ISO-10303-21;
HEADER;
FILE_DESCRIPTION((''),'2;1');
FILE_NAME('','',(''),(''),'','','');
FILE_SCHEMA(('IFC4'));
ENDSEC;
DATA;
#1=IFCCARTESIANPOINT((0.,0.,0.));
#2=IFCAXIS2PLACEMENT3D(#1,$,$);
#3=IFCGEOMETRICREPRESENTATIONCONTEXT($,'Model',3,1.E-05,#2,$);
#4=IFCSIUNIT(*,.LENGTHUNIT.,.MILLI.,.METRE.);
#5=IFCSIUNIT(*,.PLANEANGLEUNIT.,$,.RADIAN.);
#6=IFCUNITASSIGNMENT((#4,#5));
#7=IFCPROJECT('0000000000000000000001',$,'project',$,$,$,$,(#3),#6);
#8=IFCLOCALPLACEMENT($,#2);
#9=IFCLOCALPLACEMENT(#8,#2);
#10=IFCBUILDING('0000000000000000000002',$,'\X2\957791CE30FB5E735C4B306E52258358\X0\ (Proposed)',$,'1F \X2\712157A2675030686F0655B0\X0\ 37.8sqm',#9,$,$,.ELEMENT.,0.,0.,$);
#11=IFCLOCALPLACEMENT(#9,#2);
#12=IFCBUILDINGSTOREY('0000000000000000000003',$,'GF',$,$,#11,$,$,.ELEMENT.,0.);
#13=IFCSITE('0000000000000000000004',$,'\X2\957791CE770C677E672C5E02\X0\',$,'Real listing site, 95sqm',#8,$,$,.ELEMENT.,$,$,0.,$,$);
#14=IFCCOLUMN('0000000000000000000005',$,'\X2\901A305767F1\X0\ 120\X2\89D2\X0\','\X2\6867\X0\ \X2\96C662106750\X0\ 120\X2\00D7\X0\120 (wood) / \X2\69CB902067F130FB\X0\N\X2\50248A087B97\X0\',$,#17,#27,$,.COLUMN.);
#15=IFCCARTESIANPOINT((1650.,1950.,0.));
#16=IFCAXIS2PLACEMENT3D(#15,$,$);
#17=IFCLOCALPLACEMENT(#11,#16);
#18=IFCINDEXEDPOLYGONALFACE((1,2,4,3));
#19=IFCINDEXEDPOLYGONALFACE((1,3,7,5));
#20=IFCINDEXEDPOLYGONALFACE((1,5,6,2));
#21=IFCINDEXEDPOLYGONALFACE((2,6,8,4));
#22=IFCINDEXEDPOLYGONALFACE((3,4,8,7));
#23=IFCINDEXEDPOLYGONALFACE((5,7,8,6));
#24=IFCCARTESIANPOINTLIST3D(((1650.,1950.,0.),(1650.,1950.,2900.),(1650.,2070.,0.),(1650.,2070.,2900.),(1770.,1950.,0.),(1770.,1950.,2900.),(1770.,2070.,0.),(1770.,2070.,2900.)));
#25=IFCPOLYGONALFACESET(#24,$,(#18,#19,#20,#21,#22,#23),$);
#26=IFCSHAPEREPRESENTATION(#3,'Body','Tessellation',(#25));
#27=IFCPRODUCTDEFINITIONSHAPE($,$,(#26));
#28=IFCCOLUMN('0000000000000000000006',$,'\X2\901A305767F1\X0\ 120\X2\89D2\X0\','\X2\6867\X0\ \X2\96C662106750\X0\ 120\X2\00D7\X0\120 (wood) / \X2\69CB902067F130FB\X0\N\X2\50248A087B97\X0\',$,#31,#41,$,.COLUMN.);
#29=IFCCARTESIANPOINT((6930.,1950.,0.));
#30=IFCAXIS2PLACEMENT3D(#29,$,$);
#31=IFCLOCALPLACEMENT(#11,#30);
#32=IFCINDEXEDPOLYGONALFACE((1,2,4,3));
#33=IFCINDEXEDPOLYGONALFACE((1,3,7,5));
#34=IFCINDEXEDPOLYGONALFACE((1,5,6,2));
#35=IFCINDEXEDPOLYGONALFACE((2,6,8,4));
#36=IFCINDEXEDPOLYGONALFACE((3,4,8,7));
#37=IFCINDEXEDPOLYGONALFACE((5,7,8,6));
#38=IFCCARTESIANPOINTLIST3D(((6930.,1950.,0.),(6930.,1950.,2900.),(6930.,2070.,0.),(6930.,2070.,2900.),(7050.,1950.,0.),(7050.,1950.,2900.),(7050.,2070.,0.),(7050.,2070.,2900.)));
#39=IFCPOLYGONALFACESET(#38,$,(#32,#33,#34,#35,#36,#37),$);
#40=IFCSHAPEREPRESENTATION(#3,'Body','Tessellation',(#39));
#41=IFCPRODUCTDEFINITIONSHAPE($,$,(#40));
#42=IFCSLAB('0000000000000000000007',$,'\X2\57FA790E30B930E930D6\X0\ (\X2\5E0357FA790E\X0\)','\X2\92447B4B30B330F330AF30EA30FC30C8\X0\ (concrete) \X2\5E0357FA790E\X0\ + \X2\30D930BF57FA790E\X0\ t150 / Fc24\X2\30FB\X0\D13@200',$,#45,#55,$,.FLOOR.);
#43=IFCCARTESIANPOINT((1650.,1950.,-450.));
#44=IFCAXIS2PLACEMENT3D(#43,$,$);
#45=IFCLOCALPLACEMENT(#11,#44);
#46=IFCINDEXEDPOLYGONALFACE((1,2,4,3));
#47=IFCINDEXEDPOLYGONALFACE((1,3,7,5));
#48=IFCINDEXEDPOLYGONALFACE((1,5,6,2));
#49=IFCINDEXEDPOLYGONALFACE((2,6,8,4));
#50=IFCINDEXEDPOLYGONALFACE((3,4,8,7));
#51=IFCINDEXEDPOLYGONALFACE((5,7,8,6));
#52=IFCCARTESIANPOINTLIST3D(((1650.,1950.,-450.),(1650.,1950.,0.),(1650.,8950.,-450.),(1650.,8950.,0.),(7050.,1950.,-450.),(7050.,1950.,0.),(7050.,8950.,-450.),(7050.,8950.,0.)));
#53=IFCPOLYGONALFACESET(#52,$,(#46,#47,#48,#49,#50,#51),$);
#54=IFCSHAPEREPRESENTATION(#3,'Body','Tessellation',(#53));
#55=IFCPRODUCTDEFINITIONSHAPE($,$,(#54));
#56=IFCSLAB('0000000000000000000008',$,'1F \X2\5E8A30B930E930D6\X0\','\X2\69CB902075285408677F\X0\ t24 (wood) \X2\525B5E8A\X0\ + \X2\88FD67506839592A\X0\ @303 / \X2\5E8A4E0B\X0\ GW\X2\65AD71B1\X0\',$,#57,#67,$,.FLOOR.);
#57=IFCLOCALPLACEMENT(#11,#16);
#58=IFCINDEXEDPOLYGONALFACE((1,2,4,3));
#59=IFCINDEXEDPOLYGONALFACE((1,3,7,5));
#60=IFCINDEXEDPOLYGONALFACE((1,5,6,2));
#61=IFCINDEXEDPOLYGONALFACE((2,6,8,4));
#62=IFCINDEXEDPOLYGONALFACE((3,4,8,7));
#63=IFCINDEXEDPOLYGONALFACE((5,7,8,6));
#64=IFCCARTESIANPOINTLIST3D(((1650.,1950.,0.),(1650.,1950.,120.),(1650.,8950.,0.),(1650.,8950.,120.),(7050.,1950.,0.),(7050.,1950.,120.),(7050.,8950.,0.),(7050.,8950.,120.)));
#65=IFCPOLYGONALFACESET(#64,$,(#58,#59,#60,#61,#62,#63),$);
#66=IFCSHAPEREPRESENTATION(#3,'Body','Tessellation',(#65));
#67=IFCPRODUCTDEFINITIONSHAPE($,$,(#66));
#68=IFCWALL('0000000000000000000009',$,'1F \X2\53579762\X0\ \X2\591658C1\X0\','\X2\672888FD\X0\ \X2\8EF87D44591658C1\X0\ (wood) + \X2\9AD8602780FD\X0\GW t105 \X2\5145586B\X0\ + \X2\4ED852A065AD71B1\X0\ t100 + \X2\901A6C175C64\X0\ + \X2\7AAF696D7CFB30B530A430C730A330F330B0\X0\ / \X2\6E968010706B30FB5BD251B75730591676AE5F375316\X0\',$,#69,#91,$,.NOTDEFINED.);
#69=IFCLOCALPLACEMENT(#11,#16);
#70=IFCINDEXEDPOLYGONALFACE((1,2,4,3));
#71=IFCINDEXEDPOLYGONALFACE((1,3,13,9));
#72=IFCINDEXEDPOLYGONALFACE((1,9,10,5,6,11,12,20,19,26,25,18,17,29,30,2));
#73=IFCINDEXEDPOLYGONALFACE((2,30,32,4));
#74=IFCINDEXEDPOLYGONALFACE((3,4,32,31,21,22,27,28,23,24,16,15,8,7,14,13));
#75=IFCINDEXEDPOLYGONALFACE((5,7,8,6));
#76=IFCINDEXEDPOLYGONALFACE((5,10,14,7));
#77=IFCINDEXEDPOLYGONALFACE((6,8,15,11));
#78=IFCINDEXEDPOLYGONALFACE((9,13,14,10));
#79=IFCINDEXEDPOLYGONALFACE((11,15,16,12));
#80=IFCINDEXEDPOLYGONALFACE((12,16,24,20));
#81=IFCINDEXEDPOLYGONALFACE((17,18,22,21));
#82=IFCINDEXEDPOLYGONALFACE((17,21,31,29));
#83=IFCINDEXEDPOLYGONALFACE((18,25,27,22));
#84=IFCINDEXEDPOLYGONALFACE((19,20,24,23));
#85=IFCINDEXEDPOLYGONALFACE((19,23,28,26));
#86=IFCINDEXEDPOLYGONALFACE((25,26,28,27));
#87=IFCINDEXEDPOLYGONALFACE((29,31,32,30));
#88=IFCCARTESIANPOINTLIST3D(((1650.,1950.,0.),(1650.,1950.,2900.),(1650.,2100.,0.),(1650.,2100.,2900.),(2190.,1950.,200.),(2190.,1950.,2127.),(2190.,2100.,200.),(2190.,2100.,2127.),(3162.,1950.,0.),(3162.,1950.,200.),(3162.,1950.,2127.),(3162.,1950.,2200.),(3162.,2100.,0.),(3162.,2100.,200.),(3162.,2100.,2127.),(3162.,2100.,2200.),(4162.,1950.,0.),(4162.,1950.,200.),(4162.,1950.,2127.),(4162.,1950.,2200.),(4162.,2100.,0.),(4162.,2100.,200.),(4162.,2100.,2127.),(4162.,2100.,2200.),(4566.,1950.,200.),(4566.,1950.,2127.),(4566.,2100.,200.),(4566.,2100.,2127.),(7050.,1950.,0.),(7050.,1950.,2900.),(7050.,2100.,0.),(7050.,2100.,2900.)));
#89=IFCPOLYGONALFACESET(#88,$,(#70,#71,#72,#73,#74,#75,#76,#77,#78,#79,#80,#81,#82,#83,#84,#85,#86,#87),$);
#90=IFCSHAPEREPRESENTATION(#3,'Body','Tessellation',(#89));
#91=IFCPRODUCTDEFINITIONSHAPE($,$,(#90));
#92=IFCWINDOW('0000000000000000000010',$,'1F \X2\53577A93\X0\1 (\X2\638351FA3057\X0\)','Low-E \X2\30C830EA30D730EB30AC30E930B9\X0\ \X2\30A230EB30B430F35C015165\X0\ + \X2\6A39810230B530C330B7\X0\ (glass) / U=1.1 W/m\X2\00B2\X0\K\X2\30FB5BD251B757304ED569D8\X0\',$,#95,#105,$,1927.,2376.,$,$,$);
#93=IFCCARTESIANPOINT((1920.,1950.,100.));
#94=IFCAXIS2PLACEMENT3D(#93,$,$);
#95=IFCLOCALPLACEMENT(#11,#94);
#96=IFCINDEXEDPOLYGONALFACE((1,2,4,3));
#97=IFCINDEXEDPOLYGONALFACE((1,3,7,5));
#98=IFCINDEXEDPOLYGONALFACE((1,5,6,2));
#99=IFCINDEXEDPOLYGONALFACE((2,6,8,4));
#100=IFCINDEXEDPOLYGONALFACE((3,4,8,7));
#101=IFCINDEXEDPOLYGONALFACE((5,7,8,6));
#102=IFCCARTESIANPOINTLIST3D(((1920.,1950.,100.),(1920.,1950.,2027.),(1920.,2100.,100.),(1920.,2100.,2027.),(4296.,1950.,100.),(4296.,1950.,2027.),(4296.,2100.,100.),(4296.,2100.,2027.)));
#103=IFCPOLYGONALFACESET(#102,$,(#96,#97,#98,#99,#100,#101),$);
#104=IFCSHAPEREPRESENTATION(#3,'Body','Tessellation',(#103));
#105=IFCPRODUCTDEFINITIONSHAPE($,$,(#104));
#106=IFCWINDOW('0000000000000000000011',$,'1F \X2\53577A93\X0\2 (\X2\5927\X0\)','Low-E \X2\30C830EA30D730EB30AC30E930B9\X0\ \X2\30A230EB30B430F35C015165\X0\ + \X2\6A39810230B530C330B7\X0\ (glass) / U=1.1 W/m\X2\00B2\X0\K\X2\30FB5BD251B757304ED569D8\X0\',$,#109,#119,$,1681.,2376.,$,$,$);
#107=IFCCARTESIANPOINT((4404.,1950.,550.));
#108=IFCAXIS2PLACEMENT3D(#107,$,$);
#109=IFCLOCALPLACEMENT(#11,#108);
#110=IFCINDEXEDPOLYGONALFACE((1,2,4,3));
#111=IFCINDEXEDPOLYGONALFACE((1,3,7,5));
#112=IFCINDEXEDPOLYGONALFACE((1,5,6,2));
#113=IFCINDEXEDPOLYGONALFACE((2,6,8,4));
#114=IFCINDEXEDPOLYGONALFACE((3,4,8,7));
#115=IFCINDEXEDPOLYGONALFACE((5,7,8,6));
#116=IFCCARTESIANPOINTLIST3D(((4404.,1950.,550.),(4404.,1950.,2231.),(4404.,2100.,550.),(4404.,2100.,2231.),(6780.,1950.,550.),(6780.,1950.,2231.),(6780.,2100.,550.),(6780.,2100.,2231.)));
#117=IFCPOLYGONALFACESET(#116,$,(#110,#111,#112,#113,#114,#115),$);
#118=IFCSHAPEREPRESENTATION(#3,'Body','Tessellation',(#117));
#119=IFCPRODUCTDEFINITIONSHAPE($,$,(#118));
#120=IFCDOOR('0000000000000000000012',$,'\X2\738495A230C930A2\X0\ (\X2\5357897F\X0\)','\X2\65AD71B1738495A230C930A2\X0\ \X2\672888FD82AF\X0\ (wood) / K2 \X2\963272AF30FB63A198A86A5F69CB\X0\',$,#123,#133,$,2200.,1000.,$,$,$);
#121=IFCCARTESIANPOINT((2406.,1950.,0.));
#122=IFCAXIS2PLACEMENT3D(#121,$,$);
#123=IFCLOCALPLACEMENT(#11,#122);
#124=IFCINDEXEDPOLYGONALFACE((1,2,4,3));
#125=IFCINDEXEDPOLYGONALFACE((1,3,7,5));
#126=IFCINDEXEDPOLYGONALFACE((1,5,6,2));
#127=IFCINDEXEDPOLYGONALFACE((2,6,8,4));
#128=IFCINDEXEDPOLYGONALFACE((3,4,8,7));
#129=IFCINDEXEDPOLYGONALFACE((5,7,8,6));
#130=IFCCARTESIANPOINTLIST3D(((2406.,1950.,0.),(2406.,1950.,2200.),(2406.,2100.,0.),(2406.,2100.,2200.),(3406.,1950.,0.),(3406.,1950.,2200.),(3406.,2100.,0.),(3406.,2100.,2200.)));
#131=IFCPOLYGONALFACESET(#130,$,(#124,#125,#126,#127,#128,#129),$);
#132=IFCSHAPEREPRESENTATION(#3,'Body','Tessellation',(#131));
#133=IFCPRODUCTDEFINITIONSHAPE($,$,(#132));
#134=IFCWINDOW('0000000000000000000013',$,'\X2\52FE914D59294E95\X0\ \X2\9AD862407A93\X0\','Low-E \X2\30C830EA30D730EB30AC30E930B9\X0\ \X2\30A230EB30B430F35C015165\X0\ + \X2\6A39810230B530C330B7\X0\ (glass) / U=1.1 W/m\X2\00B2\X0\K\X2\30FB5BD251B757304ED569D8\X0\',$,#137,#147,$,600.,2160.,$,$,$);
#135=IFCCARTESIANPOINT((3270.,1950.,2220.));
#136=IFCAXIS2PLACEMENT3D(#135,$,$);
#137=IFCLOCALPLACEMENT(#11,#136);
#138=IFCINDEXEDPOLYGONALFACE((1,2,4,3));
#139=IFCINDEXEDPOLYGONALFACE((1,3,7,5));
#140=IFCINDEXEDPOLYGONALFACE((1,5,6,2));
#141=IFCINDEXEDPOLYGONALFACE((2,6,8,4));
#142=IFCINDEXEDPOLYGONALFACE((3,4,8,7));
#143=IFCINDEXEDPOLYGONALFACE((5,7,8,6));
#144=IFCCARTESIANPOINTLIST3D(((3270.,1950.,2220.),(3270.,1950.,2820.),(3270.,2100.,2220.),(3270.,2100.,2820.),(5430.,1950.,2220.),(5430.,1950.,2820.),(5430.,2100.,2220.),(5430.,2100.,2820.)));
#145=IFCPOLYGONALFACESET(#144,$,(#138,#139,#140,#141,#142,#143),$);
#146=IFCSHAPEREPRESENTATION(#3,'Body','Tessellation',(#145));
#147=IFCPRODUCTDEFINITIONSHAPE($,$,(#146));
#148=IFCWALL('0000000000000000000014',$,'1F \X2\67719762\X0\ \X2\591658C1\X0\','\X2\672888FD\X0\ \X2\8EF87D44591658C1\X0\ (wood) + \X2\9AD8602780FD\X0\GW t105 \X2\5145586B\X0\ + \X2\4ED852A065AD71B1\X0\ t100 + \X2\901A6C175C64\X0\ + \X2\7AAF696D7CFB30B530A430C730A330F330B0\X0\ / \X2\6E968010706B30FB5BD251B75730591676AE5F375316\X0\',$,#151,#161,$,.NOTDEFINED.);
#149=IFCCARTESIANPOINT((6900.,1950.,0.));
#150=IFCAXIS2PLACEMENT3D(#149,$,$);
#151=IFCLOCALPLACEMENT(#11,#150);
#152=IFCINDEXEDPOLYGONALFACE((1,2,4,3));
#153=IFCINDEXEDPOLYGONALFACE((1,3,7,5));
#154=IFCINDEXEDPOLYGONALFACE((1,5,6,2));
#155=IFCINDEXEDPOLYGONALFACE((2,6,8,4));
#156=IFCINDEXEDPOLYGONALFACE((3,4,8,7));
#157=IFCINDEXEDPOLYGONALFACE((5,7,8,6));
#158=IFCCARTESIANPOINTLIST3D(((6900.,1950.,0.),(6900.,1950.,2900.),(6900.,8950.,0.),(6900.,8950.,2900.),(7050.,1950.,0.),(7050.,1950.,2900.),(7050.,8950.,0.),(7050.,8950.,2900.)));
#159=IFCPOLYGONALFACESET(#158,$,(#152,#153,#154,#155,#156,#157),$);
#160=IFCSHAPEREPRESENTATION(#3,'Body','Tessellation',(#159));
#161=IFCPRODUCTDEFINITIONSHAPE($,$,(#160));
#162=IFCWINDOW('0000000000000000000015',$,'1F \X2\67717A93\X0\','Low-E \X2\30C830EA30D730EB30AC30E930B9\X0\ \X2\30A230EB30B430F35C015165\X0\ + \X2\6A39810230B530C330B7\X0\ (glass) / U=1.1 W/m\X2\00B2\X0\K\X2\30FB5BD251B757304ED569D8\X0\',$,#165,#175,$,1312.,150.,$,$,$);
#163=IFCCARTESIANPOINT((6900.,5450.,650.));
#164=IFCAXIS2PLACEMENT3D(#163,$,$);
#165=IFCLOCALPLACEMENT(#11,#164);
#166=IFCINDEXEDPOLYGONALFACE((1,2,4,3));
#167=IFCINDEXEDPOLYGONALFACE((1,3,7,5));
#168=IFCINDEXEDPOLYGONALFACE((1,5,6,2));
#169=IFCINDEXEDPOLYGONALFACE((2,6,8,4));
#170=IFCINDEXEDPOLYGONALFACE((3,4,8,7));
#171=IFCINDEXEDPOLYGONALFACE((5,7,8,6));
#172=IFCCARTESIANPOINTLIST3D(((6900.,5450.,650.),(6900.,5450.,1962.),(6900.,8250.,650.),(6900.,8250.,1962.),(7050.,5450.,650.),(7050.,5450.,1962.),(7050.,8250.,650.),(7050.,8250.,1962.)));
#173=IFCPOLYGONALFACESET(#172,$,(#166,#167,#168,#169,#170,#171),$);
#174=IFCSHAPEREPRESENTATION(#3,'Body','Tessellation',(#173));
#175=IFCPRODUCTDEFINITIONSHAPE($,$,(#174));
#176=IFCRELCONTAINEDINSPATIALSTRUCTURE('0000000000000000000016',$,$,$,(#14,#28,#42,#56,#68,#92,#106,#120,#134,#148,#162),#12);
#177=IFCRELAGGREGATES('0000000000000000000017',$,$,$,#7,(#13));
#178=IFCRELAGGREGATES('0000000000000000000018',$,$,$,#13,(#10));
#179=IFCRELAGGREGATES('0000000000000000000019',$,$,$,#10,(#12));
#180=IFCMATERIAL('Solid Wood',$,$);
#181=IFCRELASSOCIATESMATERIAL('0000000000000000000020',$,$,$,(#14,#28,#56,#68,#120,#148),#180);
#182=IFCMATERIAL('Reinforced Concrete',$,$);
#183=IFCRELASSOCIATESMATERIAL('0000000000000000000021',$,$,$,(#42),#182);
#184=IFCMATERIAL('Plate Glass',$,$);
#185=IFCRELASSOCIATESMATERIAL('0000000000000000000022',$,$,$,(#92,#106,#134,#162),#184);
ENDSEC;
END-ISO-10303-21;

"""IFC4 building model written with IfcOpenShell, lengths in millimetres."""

from ifc_helpers import new_model, si_unit, frame, frame_2d, origin, place, context, project, spatial, rectangle, extrude, material, element, fill, save


model = new_model("IFC4")

# Units and contexts
model_context = context("Model", 3, precision=1e-05, world=origin())
ifc_project = project(units=[si_unit("LENGTHUNIT", "METRE", prefix="MILLI"), si_unit("PLANEANGLEUNIT", "RADIAN")], contexts=[model_context])

# Site, building, storey
site_placement = place(None, origin())
site = spatial("IfcSite", under=ifc_project, at=site_placement, Name="長野県松本市", ObjectType="Real listing site, 95sqm", CompositionType="ELEMENT", RefElevation=0.0)
building_placement = place(site_placement, origin())
building = spatial("IfcBuilding", under=site, at=building_placement, Name="長野・平屋の別荘 (Proposed)", ObjectType="1F 無垢材と漆喰 37.8sqm", CompositionType="ELEMENT", ElevationOfRefHeight=0.0, ElevationOfTerrain=0.0)
storey_placement = place(building_placement, origin())
storey = spatial("IfcBuildingStorey", under=building, at=storey_placement, Name="GF", CompositionType="ELEMENT", Elevation=0.0)

# Columns
ifc_material_1 = material(Name="Solid Wood")
column_1_placement = place(storey_placement, frame((1650.0, 1950.0, 0.0)))
element("IfcColumn", 1, at=column_1_placement, inside=storey, material=ifc_material_1, Name="通し柱 120角", Description="桧 集成材 120×120 (wood) / 構造柱・N値計算", PredefinedType="COLUMN", context=model_context, shape_type="SweptSolid", body=[
    extrude(rectangle(XDim=120.0, YDim=120.0, at=frame_2d((60.0, 60.0))), frame((1650.0, 1950.0, 0.0)), (0.0, 0.0, 1.0), 2900.0),
])
column_2_placement = place(storey_placement, frame((6930.0, 1950.0, 0.0)))
element("IfcColumn", 2, at=column_2_placement, inside=storey, material=ifc_material_1, Name="通し柱 120角", Description="桧 集成材 120×120 (wood) / 構造柱・N値計算", PredefinedType="COLUMN", context=model_context, shape_type="SweptSolid", body=[
    extrude(rectangle(XDim=120.0, YDim=120.0, at=frame_2d((60.0, 60.0))), frame((6930.0, 1950.0, 0.0)), (0.0, 0.0, 1.0), 2900.0),
])

# Slabs
ifc_material_2 = material(Name="Reinforced Concrete")
slab_1_placement = place(storey_placement, frame((1650.0, 1950.0, -450.0)))
element("IfcSlab", 3, at=slab_1_placement, inside=storey, material=ifc_material_2, Name="基礎スラブ (布基礎)", Description="鉄筋コンクリート (concrete) 布基礎 + ベタ基礎 t150 / Fc24・D13@200", PredefinedType="FLOOR", context=model_context, shape_type="SweptSolid", body=[
    extrude(rectangle(XDim=5400.0, YDim=7000.0, at=frame_2d((2700.0, 3500.0))), frame((1650.0, 1950.0, -450.0)), (0.0, 0.0, 1.0), 450.0),
])
slab_2_placement = place(storey_placement, frame((1650.0, 1950.0, 0.0)))
element("IfcSlab", 4, at=slab_2_placement, inside=storey, material=ifc_material_1, Name="1F 床スラブ", Description="構造用合板 t24 (wood) 剛床 + 製材根太 @303 / 床下 GW断熱", PredefinedType="FLOOR", context=model_context, shape_type="SweptSolid", body=[
    extrude(rectangle(XDim=5400.0, YDim=7000.0, at=frame_2d((2700.0, 3500.0))), frame((1650.0, 1950.0, 0.0)), (0.0, 0.0, 1.0), 120.0),
])

# Wall, openings, windows, door
wall_1_placement = place(storey_placement, frame((1650.0, 1950.0, 0.0)))
wall_1 = element("IfcWall", 5, at=wall_1_placement, inside=storey, material=ifc_material_1, Name="1F 南面 外壁", Description="木製 軸組外壁 (wood) + 高性能GW t105 充填 + 付加断熱 t100 + 通気層 + 窯業系サイディング / 準耐火・寒冷地外皮強化", PredefinedType="NOTDEFINED", context=model_context, shape_type="SweptSolid", body=[
    extrude(rectangle(XDim=5400.0, YDim=150.0, at=frame_2d((2700.0, 75.0))), frame((1650.0, 1950.0, 0.0)), (0.0, 0.0, 1.0), 2900.0),
])
opening_1_placement = place(storey_placement, frame((1920.0, 1950.0, 100.0)))
opening_1 = element("IfcOpeningElement", 6, at=opening_1_placement, cuts=wall_1, PredefinedType="NOTDEFINED", context=model_context, shape_type="SweptSolid", body=[
    extrude(rectangle(XDim=2376.0, YDim=150.0, at=frame_2d((1188.0, 75.0))), frame((1920.0, 1950.0, 100.0)), (0.0, 0.0, 1.0), 1927.0),
])
opening_2_placement = place(storey_placement, frame((4404.0, 1950.0, 550.0)))
opening_2 = element("IfcOpeningElement", 7, at=opening_2_placement, cuts=wall_1, PredefinedType="NOTDEFINED", context=model_context, shape_type="SweptSolid", body=[
    extrude(rectangle(XDim=2376.0, YDim=150.0, at=frame_2d((1188.0, 75.0))), frame((4404.0, 1950.0, 550.0)), (0.0, 0.0, 1.0), 1681.0),
])
opening_3_placement = place(storey_placement, frame((2406.0, 1950.0, 0.0)))
opening_3 = element("IfcOpeningElement", 8, at=opening_3_placement, cuts=wall_1, PredefinedType="NOTDEFINED", context=model_context, shape_type="SweptSolid", body=[
    extrude(rectangle(XDim=1000.0, YDim=150.0, at=frame_2d((500.0, 75.0))), frame((2406.0, 1950.0, 0.0)), (0.0, 0.0, 1.0), 2200.0),
])
opening_4_placement = place(storey_placement, frame((3270.0, 1950.0, 2220.0)))
opening_4 = element("IfcOpeningElement", 9, at=opening_4_placement, cuts=wall_1, PredefinedType="NOTDEFINED", context=model_context, shape_type="SweptSolid", body=[
    extrude(rectangle(XDim=2160.0, YDim=150.0, at=frame_2d((1080.0, 75.0))), frame((3270.0, 1950.0, 2220.0)), (0.0, 0.0, 1.0), 600.0),
])
ifc_material_3 = material(Name="Plate Glass")
window_1_placement = place(storey_placement, frame((1920.0, 1950.0, 100.0)))
window_1 = element("IfcWindow", 10, at=window_1_placement, inside=storey, material=ifc_material_3, Name="1F 南窓1 (掃出し)", Description="Low-E トリプルガラス アルゴン封入 + 樹脂サッシ (glass) / U=1.1 W/m²K・寒冷地仕様", OverallHeight=1927.0, OverallWidth=2376.0, context=model_context, shape_type="SweptSolid", body=[
    extrude(rectangle(XDim=2376.0, YDim=150.0, at=frame_2d((1188.0, 75.0))), frame((1920.0, 1950.0, 100.0)), (0.0, 0.0, 1.0), 1927.0),
])
fill(opening_1, window_1)
window_2_placement = place(storey_placement, frame((4404.0, 1950.0, 550.0)))
window_2 = element("IfcWindow", 11, at=window_2_placement, inside=storey, material=ifc_material_3, Name="1F 南窓2 (大)", Description="Low-E トリプルガラス アルゴン封入 + 樹脂サッシ (glass) / U=1.1 W/m²K・寒冷地仕様", OverallHeight=1681.0, OverallWidth=2376.0, context=model_context, shape_type="SweptSolid", body=[
    extrude(rectangle(XDim=2376.0, YDim=150.0, at=frame_2d((1188.0, 75.0))), frame((4404.0, 1950.0, 550.0)), (0.0, 0.0, 1.0), 1681.0),
])
fill(opening_2, window_2)
door_placement = place(storey_placement, frame((2406.0, 1950.0, 0.0)))
door = element("IfcDoor", 12, at=door_placement, inside=storey, material=ifc_material_1, Name="玄関ドア (南西)", Description="断熱玄関ドア 木製芯 (wood) / K2 防犯・採風機構", OverallHeight=2200.0, OverallWidth=1000.0, context=model_context, shape_type="SweptSolid", body=[
    extrude(rectangle(XDim=1000.0, YDim=150.0, at=frame_2d((500.0, 75.0))), frame((2406.0, 1950.0, 0.0)), (0.0, 0.0, 1.0), 2200.0),
])
fill(opening_3, door)
window_3_placement = place(storey_placement, frame((3270.0, 1950.0, 2220.0)))
window_3 = element("IfcWindow", 13, at=window_3_placement, inside=storey, material=ifc_material_3, Name="勾配天井 高所窓", Description="Low-E トリプルガラス アルゴン封入 + 樹脂サッシ (glass) / U=1.1 W/m²K・寒冷地仕様", OverallHeight=600.0, OverallWidth=2160.0, context=model_context, shape_type="SweptSolid", body=[
    extrude(rectangle(XDim=2160.0, YDim=150.0, at=frame_2d((1080.0, 75.0))), frame((3270.0, 1950.0, 2220.0)), (0.0, 0.0, 1.0), 600.0),
])
fill(opening_4, window_3)

# Wall, opening, window
wall_2_placement = place(storey_placement, frame((6900.0, 1950.0, 0.0)))
wall_2 = element("IfcWall", 14, at=wall_2_placement, inside=storey, material=ifc_material_1, Name="1F 東面 外壁", Description="木製 軸組外壁 (wood) + 高性能GW t105 充填 + 付加断熱 t100 + 通気層 + 窯業系サイディング / 準耐火・寒冷地外皮強化", PredefinedType="NOTDEFINED", context=model_context, shape_type="SweptSolid", body=[
    extrude(rectangle(XDim=150.0, YDim=7000.0, at=frame_2d((75.0, 3500.0))), frame((6900.0, 1950.0, 0.0)), (0.0, 0.0, 1.0), 2900.0),
])
opening_5_placement = place(storey_placement, frame((6900.0, 5450.0, 650.0)))
opening_5 = element("IfcOpeningElement", 15, at=opening_5_placement, cuts=wall_2, PredefinedType="NOTDEFINED", context=model_context, shape_type="SweptSolid", body=[
    extrude(rectangle(XDim=150.0, YDim=2800.0, at=frame_2d((75.0, 1400.0))), frame((6900.0, 5450.0, 650.0)), (0.0, 0.0, 1.0), 1312.0),
])
window_4_placement = place(storey_placement, frame((6900.0, 5450.0, 650.0)))
window_4 = element("IfcWindow", 16, at=window_4_placement, inside=storey, material=ifc_material_3, Name="1F 東窓", Description="Low-E トリプルガラス アルゴン封入 + 樹脂サッシ (glass) / U=1.1 W/m²K・寒冷地仕様", OverallHeight=1312.0, OverallWidth=150.0, context=model_context, shape_type="SweptSolid", body=[
    extrude(rectangle(XDim=150.0, YDim=2800.0, at=frame_2d((75.0, 1400.0))), frame((6900.0, 5450.0, 650.0)), (0.0, 0.0, 1.0), 1312.0),
])
fill(opening_5, window_4)

save(model, "model.ifc")
